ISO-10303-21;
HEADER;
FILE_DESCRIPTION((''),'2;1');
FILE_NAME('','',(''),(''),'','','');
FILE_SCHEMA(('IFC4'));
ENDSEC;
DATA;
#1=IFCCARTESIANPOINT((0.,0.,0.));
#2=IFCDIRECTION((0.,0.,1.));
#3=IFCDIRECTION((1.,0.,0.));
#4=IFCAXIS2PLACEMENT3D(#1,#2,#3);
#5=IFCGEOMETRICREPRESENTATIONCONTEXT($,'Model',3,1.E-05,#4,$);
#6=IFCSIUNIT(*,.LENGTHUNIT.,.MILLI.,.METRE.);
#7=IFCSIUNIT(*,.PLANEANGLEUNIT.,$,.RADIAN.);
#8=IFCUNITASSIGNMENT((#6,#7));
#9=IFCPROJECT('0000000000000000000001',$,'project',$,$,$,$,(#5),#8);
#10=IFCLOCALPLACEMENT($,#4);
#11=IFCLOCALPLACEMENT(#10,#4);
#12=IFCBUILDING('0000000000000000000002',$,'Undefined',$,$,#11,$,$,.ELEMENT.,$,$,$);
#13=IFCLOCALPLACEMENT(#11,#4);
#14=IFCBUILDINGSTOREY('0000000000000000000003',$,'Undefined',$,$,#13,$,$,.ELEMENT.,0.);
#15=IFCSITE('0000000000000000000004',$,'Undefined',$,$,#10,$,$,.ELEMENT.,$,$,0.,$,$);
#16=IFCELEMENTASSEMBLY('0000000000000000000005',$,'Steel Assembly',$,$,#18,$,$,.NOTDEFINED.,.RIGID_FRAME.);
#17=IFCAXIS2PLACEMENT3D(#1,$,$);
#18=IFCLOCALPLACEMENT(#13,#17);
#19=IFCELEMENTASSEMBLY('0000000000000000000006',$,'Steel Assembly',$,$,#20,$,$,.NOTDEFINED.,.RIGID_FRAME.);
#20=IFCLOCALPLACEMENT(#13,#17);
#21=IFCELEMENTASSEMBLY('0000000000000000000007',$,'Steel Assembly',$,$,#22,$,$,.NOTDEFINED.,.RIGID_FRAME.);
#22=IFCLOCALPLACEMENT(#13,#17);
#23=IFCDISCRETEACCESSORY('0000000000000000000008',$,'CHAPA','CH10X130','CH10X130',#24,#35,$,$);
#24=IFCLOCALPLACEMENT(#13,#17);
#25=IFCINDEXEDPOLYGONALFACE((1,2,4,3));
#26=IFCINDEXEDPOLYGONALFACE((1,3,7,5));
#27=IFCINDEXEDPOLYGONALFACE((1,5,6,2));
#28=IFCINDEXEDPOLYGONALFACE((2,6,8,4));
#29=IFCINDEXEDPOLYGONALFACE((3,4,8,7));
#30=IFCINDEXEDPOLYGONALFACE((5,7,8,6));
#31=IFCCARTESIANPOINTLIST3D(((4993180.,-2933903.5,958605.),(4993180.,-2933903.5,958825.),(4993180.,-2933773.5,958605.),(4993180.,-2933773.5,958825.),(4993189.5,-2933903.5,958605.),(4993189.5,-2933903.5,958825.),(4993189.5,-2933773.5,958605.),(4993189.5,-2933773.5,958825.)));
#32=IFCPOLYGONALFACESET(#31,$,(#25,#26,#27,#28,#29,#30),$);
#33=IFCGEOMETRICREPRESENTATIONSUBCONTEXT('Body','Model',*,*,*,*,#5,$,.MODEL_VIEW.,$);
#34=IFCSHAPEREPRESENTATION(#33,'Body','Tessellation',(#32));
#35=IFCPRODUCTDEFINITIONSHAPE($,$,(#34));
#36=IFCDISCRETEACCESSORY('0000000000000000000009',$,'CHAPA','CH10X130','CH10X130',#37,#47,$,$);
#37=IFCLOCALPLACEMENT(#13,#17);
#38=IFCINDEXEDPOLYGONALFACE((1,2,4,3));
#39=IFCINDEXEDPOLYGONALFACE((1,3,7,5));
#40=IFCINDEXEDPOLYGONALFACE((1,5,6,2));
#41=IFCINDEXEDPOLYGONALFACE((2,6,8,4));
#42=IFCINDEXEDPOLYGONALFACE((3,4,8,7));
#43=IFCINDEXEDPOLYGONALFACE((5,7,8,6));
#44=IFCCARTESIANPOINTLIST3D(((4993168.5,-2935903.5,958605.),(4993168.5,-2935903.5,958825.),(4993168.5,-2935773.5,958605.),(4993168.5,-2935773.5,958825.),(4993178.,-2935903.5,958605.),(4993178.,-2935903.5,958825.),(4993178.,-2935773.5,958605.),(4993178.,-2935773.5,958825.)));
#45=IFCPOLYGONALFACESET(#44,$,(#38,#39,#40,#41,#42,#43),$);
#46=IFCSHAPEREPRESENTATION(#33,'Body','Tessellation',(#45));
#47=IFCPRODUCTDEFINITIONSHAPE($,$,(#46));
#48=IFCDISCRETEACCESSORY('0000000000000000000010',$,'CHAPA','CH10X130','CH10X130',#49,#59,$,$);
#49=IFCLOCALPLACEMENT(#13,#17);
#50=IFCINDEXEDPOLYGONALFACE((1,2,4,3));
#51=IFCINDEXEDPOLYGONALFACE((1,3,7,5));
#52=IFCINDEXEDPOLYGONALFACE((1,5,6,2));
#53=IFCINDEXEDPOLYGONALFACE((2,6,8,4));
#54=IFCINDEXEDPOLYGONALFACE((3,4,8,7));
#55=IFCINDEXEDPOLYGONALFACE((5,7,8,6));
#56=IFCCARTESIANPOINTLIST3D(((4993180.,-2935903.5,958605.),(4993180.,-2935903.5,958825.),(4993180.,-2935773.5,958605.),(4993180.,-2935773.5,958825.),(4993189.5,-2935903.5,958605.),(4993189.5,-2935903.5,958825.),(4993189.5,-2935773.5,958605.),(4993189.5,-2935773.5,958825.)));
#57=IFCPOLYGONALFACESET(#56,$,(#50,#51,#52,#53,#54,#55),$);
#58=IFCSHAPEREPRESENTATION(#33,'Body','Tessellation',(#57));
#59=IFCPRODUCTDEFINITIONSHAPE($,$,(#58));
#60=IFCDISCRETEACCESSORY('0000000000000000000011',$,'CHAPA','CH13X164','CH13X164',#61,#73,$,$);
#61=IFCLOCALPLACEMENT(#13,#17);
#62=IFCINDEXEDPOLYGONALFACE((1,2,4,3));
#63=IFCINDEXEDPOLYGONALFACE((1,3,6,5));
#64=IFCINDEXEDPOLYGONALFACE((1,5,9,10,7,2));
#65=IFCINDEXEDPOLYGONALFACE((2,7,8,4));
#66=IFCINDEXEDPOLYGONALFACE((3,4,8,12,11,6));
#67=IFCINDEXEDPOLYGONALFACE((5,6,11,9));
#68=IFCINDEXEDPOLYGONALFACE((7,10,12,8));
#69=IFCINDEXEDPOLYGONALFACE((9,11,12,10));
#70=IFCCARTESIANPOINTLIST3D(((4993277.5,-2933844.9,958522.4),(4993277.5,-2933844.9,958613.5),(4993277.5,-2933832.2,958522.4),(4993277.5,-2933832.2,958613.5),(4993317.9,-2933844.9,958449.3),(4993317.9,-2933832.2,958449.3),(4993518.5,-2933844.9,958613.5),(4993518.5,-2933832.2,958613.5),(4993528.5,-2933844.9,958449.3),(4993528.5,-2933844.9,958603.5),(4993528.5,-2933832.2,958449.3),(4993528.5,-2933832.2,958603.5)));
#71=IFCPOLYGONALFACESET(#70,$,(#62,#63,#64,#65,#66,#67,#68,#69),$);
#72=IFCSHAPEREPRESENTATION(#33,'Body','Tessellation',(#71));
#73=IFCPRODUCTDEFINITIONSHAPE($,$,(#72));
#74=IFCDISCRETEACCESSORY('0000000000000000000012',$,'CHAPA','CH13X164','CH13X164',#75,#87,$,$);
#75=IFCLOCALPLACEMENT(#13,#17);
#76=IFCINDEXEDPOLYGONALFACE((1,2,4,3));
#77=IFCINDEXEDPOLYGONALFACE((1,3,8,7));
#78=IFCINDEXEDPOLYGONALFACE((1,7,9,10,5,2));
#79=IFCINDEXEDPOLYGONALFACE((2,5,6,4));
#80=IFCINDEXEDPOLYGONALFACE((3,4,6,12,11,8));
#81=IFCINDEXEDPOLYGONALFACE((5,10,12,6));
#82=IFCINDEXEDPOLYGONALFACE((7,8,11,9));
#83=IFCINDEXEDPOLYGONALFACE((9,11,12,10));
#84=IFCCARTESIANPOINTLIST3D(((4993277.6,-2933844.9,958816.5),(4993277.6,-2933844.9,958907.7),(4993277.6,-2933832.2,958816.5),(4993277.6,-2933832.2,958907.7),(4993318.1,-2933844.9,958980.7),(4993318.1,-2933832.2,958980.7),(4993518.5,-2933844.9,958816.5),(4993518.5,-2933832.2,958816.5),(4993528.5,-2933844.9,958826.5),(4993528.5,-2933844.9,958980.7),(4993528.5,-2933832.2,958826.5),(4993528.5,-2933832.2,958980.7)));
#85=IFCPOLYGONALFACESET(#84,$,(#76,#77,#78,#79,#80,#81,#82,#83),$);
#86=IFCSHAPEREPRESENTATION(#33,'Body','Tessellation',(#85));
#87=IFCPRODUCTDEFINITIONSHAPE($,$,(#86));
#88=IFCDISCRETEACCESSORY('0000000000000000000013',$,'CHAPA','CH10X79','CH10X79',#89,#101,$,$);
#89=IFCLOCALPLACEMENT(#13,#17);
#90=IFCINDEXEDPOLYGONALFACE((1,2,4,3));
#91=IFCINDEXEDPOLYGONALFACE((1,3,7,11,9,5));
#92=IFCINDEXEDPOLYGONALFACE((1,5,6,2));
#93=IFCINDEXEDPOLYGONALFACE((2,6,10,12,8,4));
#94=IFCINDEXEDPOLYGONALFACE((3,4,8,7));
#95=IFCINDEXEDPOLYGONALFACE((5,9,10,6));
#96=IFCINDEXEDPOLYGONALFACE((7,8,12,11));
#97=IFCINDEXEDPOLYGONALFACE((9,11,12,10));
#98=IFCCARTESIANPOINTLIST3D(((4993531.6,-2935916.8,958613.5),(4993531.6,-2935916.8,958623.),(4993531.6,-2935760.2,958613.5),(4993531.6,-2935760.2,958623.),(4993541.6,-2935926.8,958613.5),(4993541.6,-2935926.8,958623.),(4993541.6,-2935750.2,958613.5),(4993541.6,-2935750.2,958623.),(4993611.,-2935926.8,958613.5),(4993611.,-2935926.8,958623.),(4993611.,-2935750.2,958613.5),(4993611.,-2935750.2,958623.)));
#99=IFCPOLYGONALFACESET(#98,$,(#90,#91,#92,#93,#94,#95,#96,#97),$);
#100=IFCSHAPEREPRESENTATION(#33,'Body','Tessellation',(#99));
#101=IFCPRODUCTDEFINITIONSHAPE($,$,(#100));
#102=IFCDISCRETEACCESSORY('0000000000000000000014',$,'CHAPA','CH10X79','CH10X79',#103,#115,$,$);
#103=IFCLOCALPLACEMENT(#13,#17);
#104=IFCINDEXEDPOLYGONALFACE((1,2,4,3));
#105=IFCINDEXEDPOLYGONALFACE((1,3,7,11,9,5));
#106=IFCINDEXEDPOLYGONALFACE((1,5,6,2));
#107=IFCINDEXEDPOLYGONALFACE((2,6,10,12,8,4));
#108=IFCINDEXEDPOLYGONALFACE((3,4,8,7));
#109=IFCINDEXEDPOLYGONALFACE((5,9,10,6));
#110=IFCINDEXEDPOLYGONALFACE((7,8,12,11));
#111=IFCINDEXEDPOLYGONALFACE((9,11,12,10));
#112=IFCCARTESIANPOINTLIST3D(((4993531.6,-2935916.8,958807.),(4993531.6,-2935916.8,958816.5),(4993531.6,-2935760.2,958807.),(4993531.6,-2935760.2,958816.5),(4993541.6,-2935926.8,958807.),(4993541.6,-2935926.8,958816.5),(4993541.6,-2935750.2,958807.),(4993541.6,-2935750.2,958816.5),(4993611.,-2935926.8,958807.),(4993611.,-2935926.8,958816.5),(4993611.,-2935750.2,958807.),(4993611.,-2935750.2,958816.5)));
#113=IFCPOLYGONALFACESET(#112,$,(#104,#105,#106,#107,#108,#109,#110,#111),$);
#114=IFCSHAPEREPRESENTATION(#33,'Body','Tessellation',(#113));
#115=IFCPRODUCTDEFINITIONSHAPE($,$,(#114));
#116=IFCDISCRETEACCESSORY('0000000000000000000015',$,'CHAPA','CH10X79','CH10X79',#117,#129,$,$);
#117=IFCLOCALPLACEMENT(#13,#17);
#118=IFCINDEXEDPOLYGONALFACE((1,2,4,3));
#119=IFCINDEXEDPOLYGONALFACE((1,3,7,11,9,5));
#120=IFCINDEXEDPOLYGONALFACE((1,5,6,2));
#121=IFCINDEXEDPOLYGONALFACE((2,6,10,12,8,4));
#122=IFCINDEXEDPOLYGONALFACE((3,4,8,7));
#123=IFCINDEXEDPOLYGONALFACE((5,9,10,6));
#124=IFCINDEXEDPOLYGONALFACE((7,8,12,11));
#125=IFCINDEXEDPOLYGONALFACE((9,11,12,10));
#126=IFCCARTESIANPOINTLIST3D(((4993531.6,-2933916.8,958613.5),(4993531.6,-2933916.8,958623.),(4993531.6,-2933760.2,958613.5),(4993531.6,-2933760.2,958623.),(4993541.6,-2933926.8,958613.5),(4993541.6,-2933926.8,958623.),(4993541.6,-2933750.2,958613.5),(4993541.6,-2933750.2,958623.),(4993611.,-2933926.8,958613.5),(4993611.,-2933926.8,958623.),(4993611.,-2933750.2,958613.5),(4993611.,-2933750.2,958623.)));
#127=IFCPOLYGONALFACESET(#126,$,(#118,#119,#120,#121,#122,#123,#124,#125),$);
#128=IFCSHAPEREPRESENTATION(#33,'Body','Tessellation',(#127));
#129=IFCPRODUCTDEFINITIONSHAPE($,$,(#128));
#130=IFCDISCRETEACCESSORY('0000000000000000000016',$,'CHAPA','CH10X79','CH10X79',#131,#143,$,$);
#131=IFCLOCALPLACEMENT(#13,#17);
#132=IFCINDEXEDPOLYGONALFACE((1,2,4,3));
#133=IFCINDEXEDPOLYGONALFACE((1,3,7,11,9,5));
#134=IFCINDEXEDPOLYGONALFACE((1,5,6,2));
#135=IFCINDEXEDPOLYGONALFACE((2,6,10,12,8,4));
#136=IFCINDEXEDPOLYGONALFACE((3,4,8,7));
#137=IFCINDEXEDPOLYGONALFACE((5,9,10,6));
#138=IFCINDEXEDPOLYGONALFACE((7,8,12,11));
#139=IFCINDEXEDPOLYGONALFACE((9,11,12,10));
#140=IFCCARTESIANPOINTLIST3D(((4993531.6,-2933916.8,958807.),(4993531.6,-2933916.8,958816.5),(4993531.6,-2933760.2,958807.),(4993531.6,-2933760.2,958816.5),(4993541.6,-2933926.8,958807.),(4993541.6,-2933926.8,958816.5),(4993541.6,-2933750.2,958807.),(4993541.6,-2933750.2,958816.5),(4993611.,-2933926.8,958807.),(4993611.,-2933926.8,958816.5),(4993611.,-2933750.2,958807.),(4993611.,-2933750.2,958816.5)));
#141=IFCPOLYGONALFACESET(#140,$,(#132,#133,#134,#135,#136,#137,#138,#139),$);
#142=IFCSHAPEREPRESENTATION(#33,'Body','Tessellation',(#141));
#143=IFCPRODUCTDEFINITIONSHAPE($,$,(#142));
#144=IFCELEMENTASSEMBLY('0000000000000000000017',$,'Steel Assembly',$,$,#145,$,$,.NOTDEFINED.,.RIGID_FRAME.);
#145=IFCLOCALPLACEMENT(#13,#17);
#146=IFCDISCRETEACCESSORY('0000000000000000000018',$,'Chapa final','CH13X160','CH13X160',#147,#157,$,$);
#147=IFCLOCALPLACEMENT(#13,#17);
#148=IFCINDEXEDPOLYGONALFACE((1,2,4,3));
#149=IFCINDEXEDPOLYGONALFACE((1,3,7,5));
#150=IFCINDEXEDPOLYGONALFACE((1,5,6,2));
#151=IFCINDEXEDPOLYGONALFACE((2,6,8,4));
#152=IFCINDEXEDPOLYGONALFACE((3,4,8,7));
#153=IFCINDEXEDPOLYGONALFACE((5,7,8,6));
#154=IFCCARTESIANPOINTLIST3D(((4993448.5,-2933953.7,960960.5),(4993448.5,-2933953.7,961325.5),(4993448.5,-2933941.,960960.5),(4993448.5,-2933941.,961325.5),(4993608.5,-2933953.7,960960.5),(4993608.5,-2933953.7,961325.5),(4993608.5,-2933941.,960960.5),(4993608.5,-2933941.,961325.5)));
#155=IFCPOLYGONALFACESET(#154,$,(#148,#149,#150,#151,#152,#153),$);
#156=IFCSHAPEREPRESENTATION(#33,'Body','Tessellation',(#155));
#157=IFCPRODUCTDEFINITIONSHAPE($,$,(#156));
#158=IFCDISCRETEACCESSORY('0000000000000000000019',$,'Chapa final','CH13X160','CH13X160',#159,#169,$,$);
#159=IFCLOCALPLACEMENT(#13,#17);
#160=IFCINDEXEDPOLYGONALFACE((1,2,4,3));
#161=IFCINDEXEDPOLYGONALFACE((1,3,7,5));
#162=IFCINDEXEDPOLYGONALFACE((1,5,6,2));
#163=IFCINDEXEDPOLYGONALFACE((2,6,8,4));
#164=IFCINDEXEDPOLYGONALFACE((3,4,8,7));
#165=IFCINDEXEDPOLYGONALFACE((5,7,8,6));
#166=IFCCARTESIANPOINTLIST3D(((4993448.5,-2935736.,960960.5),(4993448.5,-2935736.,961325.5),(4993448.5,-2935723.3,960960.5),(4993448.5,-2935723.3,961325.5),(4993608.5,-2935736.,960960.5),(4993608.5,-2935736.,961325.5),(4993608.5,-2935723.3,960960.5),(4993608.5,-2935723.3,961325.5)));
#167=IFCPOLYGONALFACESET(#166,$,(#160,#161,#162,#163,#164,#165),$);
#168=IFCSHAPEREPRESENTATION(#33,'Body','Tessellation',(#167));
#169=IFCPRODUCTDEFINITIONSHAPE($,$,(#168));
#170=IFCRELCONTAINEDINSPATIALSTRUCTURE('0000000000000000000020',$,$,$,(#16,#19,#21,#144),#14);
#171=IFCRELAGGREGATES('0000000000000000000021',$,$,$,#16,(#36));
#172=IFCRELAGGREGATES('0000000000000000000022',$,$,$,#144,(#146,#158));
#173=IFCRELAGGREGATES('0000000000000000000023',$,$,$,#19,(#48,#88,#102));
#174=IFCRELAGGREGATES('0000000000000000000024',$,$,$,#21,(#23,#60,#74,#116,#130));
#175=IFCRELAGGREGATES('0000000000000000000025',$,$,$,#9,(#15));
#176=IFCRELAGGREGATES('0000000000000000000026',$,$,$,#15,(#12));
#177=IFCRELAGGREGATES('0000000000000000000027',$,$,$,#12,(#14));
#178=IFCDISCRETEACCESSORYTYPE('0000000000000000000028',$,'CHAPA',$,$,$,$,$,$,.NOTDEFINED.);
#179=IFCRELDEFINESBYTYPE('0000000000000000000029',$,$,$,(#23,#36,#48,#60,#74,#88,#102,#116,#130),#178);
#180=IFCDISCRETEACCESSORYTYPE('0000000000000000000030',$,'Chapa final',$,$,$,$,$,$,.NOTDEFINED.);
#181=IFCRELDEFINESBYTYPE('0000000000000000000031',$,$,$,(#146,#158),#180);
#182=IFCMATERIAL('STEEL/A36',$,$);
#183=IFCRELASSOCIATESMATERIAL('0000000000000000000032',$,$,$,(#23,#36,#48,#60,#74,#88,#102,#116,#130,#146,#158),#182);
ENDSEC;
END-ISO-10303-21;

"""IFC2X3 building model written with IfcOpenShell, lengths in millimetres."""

from ifc_helpers import new_model, si_unit, frame, origin_with_axes, place, context, subcontext, project, spatial, polyline, outline, extrude, material, type_object, element, aggregate, save


model = new_model("IFC2X3")

# Units and contexts
model_context = context("Model", 3, precision=1e-05, world=origin_with_axes())
body_context = subcontext(model_context, "Body", "Model", "MODEL_VIEW")
ifc_project = project(units=[si_unit("LENGTHUNIT", "METRE", prefix="MILLI"), si_unit("PLANEANGLEUNIT", "RADIAN")], contexts=[model_context])

# Site, building, storey
site_placement = place(None, origin_with_axes())
site = spatial("IfcSite", under=ifc_project, at=site_placement, Name="Undefined", CompositionType="ELEMENT", RefElevation=0.0)
building_placement = place(site_placement, origin_with_axes())
building = spatial("IfcBuilding", under=site, at=building_placement, Name="Undefined", CompositionType="ELEMENT")
storey_placement = place(building_placement, origin_with_axes())
storey = spatial("IfcBuildingStorey", under=building, at=storey_placement, Name="Undefined", CompositionType="ELEMENT", Elevation=0.0)

# Element assembly
assembly_1_placement = place(storey_placement, origin_with_axes())
assembly_1 = element("IfcElementAssembly", 1, at=assembly_1_placement, inside=storey, Name="Steel Assembly", AssemblyPlace="NOTDEFINED", PredefinedType="RIGID_FRAME")

# Element assembly
assembly_2_placement = place(storey_placement, origin_with_axes())
assembly_2 = element("IfcElementAssembly", 2, at=assembly_2_placement, inside=storey, Name="Steel Assembly", AssemblyPlace="NOTDEFINED", PredefinedType="RIGID_FRAME")
ifc_material_1 = material(Name="STEEL/A36")
discrete_accessory_type_1 = type_object("IfcDiscreteAccessoryType", Name="CHAPA")

# Element assembly, discrete accessory
assembly_3_placement = place(storey_placement, origin_with_axes())
assembly_3 = element("IfcElementAssembly", 3, at=assembly_3_placement, inside=storey, Name="Steel Assembly", AssemblyPlace="NOTDEFINED", PredefinedType="RIGID_FRAME")
discrete_accessory_1_placement = place(assembly_3_placement, frame((4993184.7, -2933838.5, 958825.0), z_axis=(-1.0, 0.0, 0.0), x_axis=(0.0, 0.0, -1.0)))
discrete_accessory_1 = element("IfcDiscreteAccessory", 4, at=discrete_accessory_1_placement, type_object=discrete_accessory_type_1, material=ifc_material_1, Name="CHAPA", Description="CH10X130", ObjectType="CH10X130", context=body_context, shape_type="SweptSolid", body=[
    extrude(outline(polyline([(220.0, 65.0), (220.0, -65.0), (0.0, -65.0), (0.0, 65.0), (220.0, 65.0)])), frame((0.0, 0.0, -4.8), z_axis=(0.0, 0.0, 1.0), x_axis=(1.0, 0.0, 0.0)), (0.0, 0.0, 1.0), 9.5),
])

# Discrete accessories
discrete_accessory_2_placement = place(assembly_1_placement, frame((4993173.2, -2935838.5, 958825.0), z_axis=(-1.0, 0.0, 0.0), x_axis=(0.0, 0.0, -1.0)))
discrete_accessory_2 = element("IfcDiscreteAccessory", 5, at=discrete_accessory_2_placement, type_object=discrete_accessory_type_1, material=ifc_material_1, Name="CHAPA", Description="CH10X130", ObjectType="CH10X130", context=body_context, shape_type="SweptSolid", body=[
    extrude(outline(polyline([(220.0, 65.0), (220.0, -65.0), (0.0, -65.0), (0.0, 65.0), (220.0, 65.0)])), frame((0.0, 0.0, -4.8), z_axis=(0.0, 0.0, 1.0), x_axis=(1.0, 0.0, 0.0)), (0.0, 0.0, 1.0), 9.5),
])
aggregate(assembly_1, [discrete_accessory_2])
discrete_accessory_3_placement = place(assembly_2_placement, frame((4993184.7, -2935838.5, 958825.0), z_axis=(-1.0, 0.0, 0.0), x_axis=(0.0, 0.0, -1.0)))
discrete_accessory_3 = element("IfcDiscreteAccessory", 6, at=discrete_accessory_3_placement, type_object=discrete_accessory_type_1, material=ifc_material_1, Name="CHAPA", Description="CH10X130", ObjectType="CH10X130", context=body_context, shape_type="SweptSolid", body=[
    extrude(outline(polyline([(220.0, 65.0), (220.0, -65.0), (0.0, -65.0), (0.0, 65.0), (220.0, 65.0)])), frame((0.0, 0.0, -4.8), z_axis=(0.0, 0.0, 1.0), x_axis=(1.0, 0.0, 0.0)), (0.0, 0.0, 1.0), 9.5),
])
discrete_accessory_4_placement = place(assembly_3_placement, frame((4993277.5, -2933838.5, 958613.5), z_axis=(0.0, 1.0, 0.0), x_axis=(1.0, 0.0, 0.0)))
discrete_accessory_4 = element("IfcDiscreteAccessory", 7, at=discrete_accessory_4_placement, type_object=discrete_accessory_type_1, material=ifc_material_1, Name="CHAPA", Description="CH13X164", ObjectType="CH13X164", context=body_context, shape_type="SweptSolid", body=[
    extrude(outline(polyline([(0.0, 0.0), (241.0, 0.0), (251.0, 10.0), (251.0, 164.2), (40.4, 164.2), (0.0, 91.1), (0.0, 0.0)])), frame((0.0, 0.0, -6.3), z_axis=(0.0, 0.0, 1.0), x_axis=(1.0, 0.0, 0.0)), (0.0, 0.0, 1.0), 12.7),
])
discrete_accessory_5_placement = place(assembly_3_placement, frame((4993528.5, -2933838.5, 958816.5), z_axis=(0.0, 1.0, 0.0), x_axis=(-1.0, 0.0, 0.0)))
discrete_accessory_5 = element("IfcDiscreteAccessory", 8, at=discrete_accessory_5_placement, type_object=discrete_accessory_type_1, material=ifc_material_1, Name="CHAPA", Description="CH13X164", ObjectType="CH13X164", context=body_context, shape_type="SweptSolid", body=[
    extrude(outline(polyline([(0.0, 10.0), (10.0, 0.0), (250.9, 0.0), (250.9, 91.2), (210.4, 164.2), (0.0, 164.2), (0.0, 10.0)])), frame((0.0, 0.0, -6.3), z_axis=(0.0, 0.0, 1.0), x_axis=(1.0, 0.0, 0.0)), (0.0, 0.0, 1.0), 12.7),
])
discrete_accessory_6_placement = place(assembly_2_placement, frame((4993531.6, -2935750.2, 958618.3), z_axis=(0.0, 0.0, -1.0), x_axis=(1.0, 0.0, 0.0)))
discrete_accessory_6 = element("IfcDiscreteAccessory", 9, at=discrete_accessory_6_placement, type_object=discrete_accessory_type_1, material=ifc_material_1, Name="CHAPA", Description="CH10X79", ObjectType="CH10X79", context=body_context, shape_type="SweptSolid", body=[
    extrude(outline(polyline([(0.0, 10.0), (10.0, 0.0), (79.4, 0.0), (79.4, 176.6), (10.0, 176.6), (0.0, 166.6), (0.0, 10.0)])), frame((0.0, 0.0, -4.8), z_axis=(0.0, 0.0, 1.0), x_axis=(1.0, 0.0, 0.0)), (0.0, 0.0, 1.0), 9.5),
])
discrete_accessory_7_placement = place(assembly_2_placement, frame((4993531.6, -2935750.2, 958811.8), z_axis=(0.0, 0.0, -1.0), x_axis=(1.0, 0.0, 0.0)))
discrete_accessory_7 = element("IfcDiscreteAccessory", 10, at=discrete_accessory_7_placement, type_object=discrete_accessory_type_1, material=ifc_material_1, Name="CHAPA", Description="CH10X79", ObjectType="CH10X79", context=body_context, shape_type="SweptSolid", body=[
    extrude(outline(polyline([(0.0, 10.0), (10.0, 0.0), (79.4, 0.0), (79.4, 176.6), (10.0, 176.6), (0.0, 166.6), (0.0, 10.0)])), frame((0.0, 0.0, -4.8), z_axis=(0.0, 0.0, 1.0), x_axis=(1.0, 0.0, 0.0)), (0.0, 0.0, 1.0), 9.5),
])
discrete_accessory_8_placement = place(assembly_3_placement, frame((4993611.0, -2933926.8, 958618.3), z_axis=(0.0, 0.0, -1.0), x_axis=(-1.0, 0.0, 0.0)))
discrete_accessory_8 = element("IfcDiscreteAccessory", 11, at=discrete_accessory_8_placement, type_object=discrete_accessory_type_1, material=ifc_material_1, Name="CHAPA", Description="CH10X79", ObjectType="CH10X79", context=body_context, shape_type="SweptSolid", body=[
    extrude(outline(polyline([(0.0, 0.0), (69.4, 0.0), (79.4, 10.0), (79.4, 166.6), (69.4, 176.6), (0.0, 176.6), (0.0, 0.0)])), frame((0.0, 0.0, -4.8), z_axis=(0.0, 0.0, 1.0), x_axis=(1.0, 0.0, 0.0)), (0.0, 0.0, 1.0), 9.5),
])
discrete_accessory_9_placement = place(assembly_3_placement, frame((4993611.0, -2933926.8, 958811.8), z_axis=(0.0, 0.0, -1.0), x_axis=(-1.0, 0.0, 0.0)))
discrete_accessory_9 = element("IfcDiscreteAccessory", 12, at=discrete_accessory_9_placement, type_object=discrete_accessory_type_1, material=ifc_material_1, Name="CHAPA", Description="CH10X79", ObjectType="CH10X79", context=body_context, shape_type="SweptSolid", body=[
    extrude(outline(polyline([(0.0, 0.0), (69.4, 0.0), (79.4, 10.0), (79.4, 166.6), (69.4, 176.6), (0.0, 176.6), (0.0, 0.0)])), frame((0.0, 0.0, -4.8), z_axis=(0.0, 0.0, 1.0), x_axis=(1.0, 0.0, 0.0)), (0.0, 0.0, 1.0), 9.5),
])

# Element assembly, discrete accessories
assembly_4_placement = place(storey_placement, origin_with_axes())
assembly_4 = element("IfcElementAssembly", 13, at=assembly_4_placement, inside=storey, Name="Steel Assembly", AssemblyPlace="NOTDEFINED", PredefinedType="RIGID_FRAME")
discrete_accessory_type_2 = type_object("IfcDiscreteAccessoryType", Name="Chapa final")
discrete_accessory_10_placement = place(assembly_4_placement, frame((4993528.5, -2933947.4, 960960.5), z_axis=(0.0, -1.0, 0.0), x_axis=(0.0, 0.0, 1.0)))
discrete_accessory_10 = element("IfcDiscreteAccessory", 14, at=discrete_accessory_10_placement, type_object=discrete_accessory_type_2, material=ifc_material_1, Name="Chapa final", Description="CH13X160", ObjectType="CH13X160", context=body_context, shape_type="SweptSolid", body=[
    extrude(outline(polyline([(0.0, 80.0), (365.0, 80.0), (365.0, -80.0), (0.0, -80.0), (0.0, 80.0)])), frame((0.0, 0.0, -6.3), z_axis=(0.0, 0.0, 1.0), x_axis=(1.0, 0.0, 0.0)), (0.0, 0.0, 1.0), 12.7),
])
discrete_accessory_11_placement = place(assembly_4_placement, frame((4993528.5, -2935729.7, 960960.5), z_axis=(0.0, 1.0, 0.0), x_axis=(0.0, 0.0, 1.0)))
discrete_accessory_11 = element("IfcDiscreteAccessory", 15, at=discrete_accessory_11_placement, type_object=discrete_accessory_type_2, material=ifc_material_1, Name="Chapa final", Description="CH13X160", ObjectType="CH13X160", context=body_context, shape_type="SweptSolid", body=[
    extrude(outline(polyline([(0.0, -80.0), (0.0, 80.0), (365.0, 80.0), (365.0, -80.0), (0.0, -80.0)])), frame((0.0, 0.0, -6.3), z_axis=(0.0, 0.0, 1.0), x_axis=(1.0, 0.0, 0.0)), (0.0, 0.0, 1.0), 12.7),
])
aggregate(assembly_4, [discrete_accessory_10, discrete_accessory_11])

aggregate(assembly_2, [discrete_accessory_3, discrete_accessory_6, discrete_accessory_7])
aggregate(assembly_3, [discrete_accessory_1, discrete_accessory_4, discrete_accessory_5, discrete_accessory_8, discrete_accessory_9])

save(model, "model.ifc")
